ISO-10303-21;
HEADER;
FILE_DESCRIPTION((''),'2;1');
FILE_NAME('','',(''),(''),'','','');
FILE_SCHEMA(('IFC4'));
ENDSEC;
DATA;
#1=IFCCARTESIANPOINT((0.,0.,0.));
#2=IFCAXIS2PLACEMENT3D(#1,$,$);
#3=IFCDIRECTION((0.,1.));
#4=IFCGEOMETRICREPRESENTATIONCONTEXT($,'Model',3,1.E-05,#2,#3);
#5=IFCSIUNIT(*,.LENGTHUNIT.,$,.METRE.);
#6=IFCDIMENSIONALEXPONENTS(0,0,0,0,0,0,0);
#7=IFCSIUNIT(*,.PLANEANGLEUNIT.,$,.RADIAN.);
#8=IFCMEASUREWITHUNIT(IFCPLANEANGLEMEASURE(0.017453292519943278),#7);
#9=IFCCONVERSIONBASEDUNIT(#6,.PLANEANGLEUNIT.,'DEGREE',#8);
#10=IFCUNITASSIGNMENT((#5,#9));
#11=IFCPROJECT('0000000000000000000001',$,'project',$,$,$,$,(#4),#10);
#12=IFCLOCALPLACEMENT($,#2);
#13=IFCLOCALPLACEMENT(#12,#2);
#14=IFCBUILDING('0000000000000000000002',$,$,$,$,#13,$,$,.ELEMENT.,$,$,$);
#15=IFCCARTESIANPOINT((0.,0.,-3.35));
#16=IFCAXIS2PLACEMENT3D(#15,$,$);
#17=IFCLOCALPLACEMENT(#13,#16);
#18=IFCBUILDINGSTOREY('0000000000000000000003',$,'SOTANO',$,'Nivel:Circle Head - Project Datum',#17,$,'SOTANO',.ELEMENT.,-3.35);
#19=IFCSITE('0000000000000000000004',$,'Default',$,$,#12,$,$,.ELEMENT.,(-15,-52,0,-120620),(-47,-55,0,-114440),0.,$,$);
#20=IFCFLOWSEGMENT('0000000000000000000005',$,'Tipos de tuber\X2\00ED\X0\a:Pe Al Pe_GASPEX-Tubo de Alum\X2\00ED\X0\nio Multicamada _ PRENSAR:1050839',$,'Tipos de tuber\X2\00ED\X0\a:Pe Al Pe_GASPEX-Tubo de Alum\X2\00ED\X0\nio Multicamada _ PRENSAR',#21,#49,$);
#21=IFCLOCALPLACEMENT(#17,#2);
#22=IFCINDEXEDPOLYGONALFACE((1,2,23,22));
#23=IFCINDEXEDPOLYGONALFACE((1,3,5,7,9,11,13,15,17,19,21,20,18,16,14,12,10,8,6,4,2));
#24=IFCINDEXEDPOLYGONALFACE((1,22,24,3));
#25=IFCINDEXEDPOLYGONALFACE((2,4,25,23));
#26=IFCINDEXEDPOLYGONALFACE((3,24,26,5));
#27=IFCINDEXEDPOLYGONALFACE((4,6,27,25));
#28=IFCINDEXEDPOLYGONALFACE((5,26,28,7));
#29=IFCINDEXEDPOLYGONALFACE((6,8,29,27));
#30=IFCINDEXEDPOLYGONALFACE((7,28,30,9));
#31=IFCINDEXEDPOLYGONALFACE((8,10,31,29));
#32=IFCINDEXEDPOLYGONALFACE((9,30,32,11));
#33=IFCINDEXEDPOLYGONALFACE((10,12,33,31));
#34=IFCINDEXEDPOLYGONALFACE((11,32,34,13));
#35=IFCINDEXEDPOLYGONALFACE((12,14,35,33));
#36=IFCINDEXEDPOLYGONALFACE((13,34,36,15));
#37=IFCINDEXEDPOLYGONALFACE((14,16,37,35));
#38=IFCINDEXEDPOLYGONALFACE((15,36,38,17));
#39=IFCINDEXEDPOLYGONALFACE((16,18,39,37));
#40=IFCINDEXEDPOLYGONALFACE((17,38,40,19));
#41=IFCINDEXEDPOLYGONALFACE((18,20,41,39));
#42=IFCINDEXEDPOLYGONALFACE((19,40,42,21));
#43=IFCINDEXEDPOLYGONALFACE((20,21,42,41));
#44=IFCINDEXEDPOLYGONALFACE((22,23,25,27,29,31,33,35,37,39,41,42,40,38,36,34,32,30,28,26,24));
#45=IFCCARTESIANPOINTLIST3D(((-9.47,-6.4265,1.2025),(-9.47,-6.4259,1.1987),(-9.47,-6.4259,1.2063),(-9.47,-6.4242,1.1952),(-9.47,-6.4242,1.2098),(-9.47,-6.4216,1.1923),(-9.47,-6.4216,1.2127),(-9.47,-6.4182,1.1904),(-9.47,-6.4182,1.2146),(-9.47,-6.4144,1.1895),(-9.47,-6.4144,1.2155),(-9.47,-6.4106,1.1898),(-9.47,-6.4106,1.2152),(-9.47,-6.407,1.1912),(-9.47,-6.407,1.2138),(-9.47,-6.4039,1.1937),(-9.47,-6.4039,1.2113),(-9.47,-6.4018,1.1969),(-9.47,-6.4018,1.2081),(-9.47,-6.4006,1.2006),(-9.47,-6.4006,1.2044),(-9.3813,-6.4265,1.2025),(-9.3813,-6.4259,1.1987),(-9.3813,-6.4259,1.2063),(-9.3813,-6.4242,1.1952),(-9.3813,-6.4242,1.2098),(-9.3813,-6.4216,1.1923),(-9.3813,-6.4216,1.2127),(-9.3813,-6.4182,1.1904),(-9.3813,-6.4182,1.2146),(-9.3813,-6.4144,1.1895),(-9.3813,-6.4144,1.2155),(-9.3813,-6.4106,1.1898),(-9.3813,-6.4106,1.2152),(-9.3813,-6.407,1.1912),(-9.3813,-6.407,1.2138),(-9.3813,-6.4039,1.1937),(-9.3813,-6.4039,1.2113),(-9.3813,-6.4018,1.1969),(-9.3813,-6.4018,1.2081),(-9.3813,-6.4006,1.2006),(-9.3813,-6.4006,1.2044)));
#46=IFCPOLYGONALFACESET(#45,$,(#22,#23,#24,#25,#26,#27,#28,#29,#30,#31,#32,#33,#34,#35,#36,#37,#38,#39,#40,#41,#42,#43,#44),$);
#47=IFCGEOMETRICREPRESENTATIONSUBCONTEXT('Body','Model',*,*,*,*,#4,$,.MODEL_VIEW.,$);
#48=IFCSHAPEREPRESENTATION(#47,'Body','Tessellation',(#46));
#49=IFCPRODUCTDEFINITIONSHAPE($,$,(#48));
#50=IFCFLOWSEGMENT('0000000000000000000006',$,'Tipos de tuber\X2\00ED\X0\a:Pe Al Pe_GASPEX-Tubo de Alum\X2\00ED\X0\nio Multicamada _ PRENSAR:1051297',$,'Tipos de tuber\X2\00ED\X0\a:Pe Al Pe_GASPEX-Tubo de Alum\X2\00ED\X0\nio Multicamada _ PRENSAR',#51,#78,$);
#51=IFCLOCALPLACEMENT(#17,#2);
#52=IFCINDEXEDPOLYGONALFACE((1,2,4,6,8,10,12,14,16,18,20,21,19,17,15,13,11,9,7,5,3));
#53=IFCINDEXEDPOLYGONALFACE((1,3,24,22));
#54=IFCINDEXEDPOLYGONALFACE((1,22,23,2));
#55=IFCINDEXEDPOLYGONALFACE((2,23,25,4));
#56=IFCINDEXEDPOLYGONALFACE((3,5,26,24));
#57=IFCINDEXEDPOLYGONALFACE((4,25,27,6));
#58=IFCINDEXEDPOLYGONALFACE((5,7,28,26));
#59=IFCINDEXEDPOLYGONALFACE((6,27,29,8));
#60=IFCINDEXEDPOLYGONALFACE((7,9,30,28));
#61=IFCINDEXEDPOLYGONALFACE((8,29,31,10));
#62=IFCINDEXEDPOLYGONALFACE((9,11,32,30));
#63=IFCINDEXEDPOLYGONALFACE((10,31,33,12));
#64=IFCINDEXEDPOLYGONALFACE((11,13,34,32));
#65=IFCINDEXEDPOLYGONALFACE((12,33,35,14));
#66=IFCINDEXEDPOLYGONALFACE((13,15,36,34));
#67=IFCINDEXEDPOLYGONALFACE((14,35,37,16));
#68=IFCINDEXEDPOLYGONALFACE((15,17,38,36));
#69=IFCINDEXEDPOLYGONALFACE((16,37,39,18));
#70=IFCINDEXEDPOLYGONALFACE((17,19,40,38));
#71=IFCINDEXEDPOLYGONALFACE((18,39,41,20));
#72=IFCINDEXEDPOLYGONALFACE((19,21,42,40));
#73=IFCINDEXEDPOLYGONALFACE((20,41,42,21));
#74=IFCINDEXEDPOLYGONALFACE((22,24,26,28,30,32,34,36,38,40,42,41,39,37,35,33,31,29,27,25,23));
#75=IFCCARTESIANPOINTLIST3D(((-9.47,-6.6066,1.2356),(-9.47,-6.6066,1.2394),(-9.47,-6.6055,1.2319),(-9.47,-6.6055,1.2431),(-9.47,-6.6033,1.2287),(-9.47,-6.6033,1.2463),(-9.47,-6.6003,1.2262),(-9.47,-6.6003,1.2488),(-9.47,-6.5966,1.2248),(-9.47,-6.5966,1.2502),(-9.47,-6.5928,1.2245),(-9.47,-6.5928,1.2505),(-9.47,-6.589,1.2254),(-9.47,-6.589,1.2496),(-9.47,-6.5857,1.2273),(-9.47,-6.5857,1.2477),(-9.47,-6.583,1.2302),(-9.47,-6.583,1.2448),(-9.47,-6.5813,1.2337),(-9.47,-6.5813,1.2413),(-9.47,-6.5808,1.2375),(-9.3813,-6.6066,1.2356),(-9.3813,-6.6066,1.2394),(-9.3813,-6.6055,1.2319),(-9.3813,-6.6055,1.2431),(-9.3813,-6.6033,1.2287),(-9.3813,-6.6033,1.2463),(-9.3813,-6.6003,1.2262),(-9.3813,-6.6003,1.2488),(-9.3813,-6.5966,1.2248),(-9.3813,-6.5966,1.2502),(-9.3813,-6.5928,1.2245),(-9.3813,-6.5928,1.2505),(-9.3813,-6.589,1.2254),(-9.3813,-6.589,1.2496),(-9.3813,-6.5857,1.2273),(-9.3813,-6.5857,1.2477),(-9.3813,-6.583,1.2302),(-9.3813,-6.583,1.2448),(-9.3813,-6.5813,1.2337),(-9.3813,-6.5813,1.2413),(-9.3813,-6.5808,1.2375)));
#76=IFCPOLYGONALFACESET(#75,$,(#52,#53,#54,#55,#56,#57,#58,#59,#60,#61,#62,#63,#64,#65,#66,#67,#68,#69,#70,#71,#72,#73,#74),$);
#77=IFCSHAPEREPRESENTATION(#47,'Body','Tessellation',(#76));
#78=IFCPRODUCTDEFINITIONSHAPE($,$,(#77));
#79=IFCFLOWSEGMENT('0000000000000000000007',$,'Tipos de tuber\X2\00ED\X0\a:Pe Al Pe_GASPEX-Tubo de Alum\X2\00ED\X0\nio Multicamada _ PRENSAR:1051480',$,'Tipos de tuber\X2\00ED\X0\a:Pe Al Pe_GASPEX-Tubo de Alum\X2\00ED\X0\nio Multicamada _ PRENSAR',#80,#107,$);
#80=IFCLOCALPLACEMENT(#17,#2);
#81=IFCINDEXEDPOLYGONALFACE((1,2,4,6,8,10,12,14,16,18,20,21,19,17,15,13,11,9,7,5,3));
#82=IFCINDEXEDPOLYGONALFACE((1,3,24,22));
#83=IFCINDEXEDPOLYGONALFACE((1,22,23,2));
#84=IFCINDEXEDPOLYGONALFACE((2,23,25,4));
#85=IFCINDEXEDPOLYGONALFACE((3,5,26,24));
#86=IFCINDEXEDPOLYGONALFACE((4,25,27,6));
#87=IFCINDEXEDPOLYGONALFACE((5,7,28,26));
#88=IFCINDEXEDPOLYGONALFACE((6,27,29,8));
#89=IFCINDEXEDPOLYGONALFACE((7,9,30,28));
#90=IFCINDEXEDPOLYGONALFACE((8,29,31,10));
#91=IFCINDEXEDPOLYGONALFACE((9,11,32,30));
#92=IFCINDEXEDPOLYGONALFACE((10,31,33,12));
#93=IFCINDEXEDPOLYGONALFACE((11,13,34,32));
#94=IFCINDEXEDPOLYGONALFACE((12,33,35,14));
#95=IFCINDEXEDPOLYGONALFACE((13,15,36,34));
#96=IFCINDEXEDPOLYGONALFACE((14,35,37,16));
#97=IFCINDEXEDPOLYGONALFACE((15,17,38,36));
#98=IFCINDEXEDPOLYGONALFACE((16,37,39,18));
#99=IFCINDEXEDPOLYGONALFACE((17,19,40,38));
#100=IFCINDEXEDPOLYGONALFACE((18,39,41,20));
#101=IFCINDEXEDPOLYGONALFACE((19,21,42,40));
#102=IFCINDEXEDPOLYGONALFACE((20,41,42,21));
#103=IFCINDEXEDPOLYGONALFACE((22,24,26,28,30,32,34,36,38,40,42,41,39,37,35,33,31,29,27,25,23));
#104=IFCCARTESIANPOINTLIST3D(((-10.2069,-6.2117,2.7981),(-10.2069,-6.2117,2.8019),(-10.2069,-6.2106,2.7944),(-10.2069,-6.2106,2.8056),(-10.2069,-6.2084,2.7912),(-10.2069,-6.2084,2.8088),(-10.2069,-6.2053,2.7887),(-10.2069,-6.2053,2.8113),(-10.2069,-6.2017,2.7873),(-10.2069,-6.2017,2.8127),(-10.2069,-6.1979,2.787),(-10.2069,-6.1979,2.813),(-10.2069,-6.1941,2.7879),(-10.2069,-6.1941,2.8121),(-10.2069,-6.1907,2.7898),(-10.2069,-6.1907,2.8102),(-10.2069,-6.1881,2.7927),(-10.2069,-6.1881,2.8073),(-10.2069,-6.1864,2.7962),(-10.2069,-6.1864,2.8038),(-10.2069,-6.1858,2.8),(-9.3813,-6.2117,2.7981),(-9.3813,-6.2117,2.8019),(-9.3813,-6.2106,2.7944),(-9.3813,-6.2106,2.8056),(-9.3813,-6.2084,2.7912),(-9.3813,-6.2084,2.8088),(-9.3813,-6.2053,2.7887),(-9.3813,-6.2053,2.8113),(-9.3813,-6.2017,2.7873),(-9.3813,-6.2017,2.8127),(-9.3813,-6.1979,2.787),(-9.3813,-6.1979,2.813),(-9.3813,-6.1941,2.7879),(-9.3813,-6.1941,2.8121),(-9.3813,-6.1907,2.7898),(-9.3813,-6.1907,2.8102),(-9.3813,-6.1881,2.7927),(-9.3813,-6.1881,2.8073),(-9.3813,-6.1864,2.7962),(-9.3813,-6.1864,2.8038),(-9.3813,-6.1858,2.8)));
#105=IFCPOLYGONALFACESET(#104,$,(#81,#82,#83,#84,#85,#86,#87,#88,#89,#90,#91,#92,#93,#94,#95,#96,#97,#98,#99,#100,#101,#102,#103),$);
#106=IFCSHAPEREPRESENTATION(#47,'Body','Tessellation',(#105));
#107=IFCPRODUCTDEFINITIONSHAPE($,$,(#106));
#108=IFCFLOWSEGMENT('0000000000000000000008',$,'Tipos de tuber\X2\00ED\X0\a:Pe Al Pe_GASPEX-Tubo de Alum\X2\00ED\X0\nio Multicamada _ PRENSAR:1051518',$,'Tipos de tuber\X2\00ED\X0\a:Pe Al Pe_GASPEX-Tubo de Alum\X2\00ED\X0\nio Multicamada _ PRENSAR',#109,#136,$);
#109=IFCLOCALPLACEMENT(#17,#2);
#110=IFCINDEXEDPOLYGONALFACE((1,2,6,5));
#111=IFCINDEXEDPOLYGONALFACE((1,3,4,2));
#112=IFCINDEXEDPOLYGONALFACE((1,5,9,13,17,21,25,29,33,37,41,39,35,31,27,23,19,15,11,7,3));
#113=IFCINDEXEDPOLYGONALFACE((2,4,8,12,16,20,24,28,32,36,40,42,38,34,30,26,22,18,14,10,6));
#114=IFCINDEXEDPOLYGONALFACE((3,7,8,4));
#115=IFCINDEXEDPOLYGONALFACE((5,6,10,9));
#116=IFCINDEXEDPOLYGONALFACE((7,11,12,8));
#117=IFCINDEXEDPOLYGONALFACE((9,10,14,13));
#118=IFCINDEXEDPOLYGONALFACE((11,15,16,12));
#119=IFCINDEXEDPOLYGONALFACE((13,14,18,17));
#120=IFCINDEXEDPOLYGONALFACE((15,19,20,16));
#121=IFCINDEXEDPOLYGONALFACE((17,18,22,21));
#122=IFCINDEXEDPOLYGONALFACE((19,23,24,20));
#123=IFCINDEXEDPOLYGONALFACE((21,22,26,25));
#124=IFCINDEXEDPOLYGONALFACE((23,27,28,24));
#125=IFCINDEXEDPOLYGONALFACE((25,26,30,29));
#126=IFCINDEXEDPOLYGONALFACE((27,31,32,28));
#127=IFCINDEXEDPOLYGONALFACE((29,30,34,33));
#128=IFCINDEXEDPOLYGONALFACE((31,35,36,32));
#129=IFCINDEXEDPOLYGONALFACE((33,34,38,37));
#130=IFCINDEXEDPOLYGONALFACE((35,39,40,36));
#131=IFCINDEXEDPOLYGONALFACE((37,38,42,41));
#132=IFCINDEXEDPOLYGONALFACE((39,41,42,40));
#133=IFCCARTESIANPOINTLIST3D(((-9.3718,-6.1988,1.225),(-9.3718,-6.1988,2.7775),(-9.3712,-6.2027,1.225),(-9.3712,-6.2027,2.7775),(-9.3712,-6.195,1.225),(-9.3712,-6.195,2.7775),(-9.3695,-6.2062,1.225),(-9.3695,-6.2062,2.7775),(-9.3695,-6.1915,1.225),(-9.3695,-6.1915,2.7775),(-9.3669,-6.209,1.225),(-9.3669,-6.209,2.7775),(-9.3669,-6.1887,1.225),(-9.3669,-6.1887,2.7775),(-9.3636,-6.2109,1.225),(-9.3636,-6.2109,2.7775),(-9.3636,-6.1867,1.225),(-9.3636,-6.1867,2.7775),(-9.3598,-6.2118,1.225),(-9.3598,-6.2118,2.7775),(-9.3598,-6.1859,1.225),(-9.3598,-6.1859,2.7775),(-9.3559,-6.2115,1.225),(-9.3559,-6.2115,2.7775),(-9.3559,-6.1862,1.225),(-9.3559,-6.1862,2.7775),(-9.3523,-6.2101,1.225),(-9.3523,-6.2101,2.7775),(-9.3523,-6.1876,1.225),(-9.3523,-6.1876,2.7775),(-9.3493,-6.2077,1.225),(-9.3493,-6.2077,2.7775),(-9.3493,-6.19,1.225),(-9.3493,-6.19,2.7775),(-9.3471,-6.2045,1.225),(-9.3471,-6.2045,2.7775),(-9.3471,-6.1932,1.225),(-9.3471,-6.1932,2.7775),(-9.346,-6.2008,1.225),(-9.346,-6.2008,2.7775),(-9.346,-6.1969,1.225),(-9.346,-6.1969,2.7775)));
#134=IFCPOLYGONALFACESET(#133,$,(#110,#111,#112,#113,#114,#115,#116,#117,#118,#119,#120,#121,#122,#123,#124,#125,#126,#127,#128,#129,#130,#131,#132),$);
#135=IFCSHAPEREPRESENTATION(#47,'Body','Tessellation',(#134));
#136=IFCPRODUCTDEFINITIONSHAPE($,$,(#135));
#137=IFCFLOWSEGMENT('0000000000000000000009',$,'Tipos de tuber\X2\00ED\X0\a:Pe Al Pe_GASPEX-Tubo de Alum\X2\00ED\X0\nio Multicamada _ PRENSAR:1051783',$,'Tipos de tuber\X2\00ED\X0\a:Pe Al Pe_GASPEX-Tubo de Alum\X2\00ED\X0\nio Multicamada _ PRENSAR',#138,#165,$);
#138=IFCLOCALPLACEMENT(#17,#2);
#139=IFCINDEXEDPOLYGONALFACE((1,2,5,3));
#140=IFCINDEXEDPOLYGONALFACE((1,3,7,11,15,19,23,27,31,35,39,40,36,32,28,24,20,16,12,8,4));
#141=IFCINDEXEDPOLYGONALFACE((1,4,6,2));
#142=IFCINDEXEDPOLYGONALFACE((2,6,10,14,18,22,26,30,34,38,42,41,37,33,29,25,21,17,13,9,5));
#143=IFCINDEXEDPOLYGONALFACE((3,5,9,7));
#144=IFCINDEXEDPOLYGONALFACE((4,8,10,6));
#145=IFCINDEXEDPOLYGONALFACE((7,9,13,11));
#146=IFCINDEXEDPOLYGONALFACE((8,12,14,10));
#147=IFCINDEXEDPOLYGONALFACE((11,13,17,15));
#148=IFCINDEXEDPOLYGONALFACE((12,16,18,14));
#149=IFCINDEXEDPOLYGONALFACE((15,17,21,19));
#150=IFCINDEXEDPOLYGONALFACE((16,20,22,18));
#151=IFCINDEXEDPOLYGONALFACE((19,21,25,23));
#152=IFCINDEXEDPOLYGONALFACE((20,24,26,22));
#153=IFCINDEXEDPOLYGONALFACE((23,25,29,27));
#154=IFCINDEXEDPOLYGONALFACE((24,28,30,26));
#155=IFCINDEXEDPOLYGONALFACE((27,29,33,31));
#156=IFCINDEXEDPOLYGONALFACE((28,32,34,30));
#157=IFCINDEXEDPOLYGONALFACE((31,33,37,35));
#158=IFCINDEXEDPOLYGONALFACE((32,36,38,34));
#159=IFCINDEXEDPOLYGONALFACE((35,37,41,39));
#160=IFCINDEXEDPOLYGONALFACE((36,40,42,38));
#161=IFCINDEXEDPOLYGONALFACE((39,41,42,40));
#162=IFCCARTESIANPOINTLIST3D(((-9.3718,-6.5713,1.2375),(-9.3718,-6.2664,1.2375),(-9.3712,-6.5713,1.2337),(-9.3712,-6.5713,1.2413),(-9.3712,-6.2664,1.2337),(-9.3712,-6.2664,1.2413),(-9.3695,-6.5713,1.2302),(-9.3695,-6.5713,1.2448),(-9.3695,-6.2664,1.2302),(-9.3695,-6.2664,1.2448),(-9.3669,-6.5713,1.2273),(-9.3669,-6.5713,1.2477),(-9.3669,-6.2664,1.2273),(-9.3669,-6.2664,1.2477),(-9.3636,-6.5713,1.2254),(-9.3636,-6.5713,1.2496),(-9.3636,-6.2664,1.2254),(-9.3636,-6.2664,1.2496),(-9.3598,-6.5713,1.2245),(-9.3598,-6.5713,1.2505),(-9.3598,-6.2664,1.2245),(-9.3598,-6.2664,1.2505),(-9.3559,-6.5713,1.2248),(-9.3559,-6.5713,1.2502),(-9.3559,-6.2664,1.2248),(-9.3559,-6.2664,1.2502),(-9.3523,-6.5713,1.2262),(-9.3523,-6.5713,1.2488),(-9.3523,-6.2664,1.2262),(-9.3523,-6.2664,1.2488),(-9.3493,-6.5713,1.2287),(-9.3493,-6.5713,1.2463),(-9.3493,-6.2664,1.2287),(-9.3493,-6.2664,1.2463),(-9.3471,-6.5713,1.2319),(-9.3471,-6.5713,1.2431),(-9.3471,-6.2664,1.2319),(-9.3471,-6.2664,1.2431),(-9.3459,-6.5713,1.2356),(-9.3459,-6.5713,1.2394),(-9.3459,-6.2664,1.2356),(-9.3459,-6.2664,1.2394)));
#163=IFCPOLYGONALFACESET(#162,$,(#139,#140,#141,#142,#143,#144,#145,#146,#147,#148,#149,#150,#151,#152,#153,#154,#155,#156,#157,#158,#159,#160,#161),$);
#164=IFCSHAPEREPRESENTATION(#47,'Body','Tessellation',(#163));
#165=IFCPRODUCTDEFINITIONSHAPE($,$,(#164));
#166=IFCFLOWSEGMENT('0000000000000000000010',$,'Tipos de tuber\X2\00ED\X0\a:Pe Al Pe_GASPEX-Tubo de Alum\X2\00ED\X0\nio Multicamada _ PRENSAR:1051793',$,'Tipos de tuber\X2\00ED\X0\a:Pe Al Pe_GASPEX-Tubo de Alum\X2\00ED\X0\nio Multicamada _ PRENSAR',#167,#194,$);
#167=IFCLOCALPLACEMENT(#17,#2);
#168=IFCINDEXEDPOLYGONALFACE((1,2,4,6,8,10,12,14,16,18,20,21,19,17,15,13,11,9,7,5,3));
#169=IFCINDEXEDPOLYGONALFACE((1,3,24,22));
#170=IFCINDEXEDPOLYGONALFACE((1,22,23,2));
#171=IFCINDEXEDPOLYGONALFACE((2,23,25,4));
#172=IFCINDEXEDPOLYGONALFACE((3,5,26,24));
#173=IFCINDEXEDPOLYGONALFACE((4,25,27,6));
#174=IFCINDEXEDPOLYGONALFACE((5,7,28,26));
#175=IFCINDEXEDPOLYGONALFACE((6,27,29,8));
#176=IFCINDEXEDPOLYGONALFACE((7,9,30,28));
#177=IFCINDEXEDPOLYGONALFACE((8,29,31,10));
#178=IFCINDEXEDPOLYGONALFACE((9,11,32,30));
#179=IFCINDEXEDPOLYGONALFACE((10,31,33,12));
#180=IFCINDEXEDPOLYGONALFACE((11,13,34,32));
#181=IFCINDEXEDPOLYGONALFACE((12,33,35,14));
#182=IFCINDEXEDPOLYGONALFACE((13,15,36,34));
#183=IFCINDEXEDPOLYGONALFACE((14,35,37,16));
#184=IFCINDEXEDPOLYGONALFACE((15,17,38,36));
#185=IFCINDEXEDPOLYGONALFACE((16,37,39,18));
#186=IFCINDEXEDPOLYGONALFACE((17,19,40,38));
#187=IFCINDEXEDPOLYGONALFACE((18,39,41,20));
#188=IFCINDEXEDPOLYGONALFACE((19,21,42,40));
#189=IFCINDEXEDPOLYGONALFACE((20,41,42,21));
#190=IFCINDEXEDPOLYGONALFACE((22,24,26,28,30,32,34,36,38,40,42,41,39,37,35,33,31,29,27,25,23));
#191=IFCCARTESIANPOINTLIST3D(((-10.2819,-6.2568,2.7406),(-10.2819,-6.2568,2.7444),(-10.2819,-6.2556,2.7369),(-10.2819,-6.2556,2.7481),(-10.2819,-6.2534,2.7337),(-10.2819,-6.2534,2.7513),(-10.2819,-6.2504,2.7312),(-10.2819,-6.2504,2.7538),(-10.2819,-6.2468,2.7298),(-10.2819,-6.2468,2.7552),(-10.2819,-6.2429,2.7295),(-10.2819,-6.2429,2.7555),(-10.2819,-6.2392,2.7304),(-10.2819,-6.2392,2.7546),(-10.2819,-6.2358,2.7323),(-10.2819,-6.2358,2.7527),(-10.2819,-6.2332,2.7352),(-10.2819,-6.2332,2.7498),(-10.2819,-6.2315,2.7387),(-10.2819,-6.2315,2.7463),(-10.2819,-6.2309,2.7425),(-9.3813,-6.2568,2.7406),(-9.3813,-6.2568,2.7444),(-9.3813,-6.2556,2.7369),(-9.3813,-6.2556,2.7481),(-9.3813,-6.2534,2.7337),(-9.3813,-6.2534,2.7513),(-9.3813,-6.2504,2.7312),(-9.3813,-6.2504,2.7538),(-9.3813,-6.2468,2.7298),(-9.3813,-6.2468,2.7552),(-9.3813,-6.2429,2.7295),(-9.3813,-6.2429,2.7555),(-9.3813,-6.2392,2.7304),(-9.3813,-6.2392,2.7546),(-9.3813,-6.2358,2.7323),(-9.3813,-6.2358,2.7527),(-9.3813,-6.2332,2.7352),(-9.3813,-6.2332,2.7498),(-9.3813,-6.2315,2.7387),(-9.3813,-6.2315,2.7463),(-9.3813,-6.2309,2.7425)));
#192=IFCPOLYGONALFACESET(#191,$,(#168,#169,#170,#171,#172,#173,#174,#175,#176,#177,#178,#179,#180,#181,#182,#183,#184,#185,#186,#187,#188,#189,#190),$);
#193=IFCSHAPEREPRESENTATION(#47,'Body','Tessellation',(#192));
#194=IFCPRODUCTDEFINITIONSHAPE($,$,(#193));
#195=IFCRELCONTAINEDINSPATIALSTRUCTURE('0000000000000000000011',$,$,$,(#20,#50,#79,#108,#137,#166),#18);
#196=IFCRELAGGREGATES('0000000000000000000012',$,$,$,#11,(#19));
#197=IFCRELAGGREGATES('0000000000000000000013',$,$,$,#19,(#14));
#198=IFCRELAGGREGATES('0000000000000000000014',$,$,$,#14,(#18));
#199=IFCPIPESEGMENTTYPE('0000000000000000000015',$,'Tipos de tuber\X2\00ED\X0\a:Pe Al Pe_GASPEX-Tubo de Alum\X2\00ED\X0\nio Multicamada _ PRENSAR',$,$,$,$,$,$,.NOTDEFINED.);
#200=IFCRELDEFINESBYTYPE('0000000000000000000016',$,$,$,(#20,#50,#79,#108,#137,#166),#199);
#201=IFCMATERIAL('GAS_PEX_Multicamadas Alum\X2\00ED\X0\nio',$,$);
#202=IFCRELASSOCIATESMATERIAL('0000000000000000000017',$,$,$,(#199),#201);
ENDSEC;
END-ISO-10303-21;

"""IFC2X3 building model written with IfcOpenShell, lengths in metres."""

from ifc_helpers import new_model, entity, si_unit, converted_unit, direction, frame, frame_2d, origin, origin_2d_with_axis, place, context, subcontext, project, spatial, circle, extrude, material, type_object, element, save


model = new_model("IFC2X3")

# Units and contexts
model_context = context("Model", 3, precision=1e-05, world=origin(), true_north=direction((0.0, 1.0)))
body_context = subcontext(model_context, "Body", "Model", "MODEL_VIEW")
ifc_project = project(units=[si_unit("LENGTHUNIT", "METRE"), converted_unit("PLANEANGLEUNIT", "DEGREE", entity("IfcPlaneAngleMeasure", 0.017453292519943278), si_unit("PLANEANGLEUNIT", "RADIAN"), dimensions=[0, 0, 0, 0, 0, 0, 0])], contexts=[model_context])

# Site, building, storey
site_placement = place(None, origin())
site = spatial("IfcSite", under=ifc_project, at=site_placement, Name="Default", CompositionType="ELEMENT", RefLatitude=(-15, -52, 0, -120620), RefLongitude=(-47, -55, 0, -114440), RefElevation=0.0)
building_placement = place(site_placement, origin())
building = spatial("IfcBuilding", under=site, at=building_placement, CompositionType="ELEMENT")
storey_placement = place(building_placement, frame((0.0, 0.0, -3.35)))
storey = spatial("IfcBuildingStorey", under=building, at=storey_placement, Name="SOTANO", ObjectType="Nivel:Circle Head - Project Datum", LongName="SOTANO", CompositionType="ELEMENT", Elevation=-3.35)

# Flow segments
ifc_material = material(Name="GAS_PEX_Multicamadas Alumínio")
pipe_segment_type_1 = type_object("IfcPipeSegmentType", Name="Tipos de tubería:Pe Al Pe_GASPEX-Tubo de Alumínio Multicamada _ PRENSAR", PredefinedType="NOTDEFINED", material=ifc_material)
flow_segment_1_placement = place(storey_placement, origin())
element("IfcFlowSegment", 1, at=flow_segment_1_placement, inside=storey, type_object=pipe_segment_type_1, Name="Tipos de tubería:Pe Al Pe_GASPEX-Tubo de Alumínio Multicamada _ PRENSAR:1050839", ObjectType="Tipos de tubería:Pe Al Pe_GASPEX-Tubo de Alumínio Multicamada _ PRENSAR", context=body_context, shape_type="SweptSolid", body=[
    extrude(circle(Radius=0.013, at=frame_2d((0.0, 0.0), x_axis=(1.0, 0.0))), frame((-9.47, -6.4135, 1.2025), z_axis=(1.0, -0.000001, 0.0), x_axis=(-0.000001, -1.0, 0.0)), (0.0, 0.0, 1.0), 0.0887),
])
flow_segment_2_placement = place(storey_placement, origin())
element("IfcFlowSegment", 2, at=flow_segment_2_placement, inside=storey, type_object=pipe_segment_type_1, Name="Tipos de tubería:Pe Al Pe_GASPEX-Tubo de Alumínio Multicamada _ PRENSAR:1051297", ObjectType="Tipos de tubería:Pe Al Pe_GASPEX-Tubo de Alumínio Multicamada _ PRENSAR", context=body_context, shape_type="SweptSolid", body=[
    extrude(circle(Radius=0.013, at=frame_2d((0.0, 0.0), x_axis=(1.0, 0.0))), frame((-9.47, -6.5938, 1.2375), z_axis=(1.0, 0.0, 0.0), x_axis=(0.0, 1.0, 0.0)), (0.0, 0.0, 1.0), 0.0887),
])
flow_segment_3_placement = place(storey_placement, origin())
element("IfcFlowSegment", 3, at=flow_segment_3_placement, inside=storey, type_object=pipe_segment_type_1, Name="Tipos de tubería:Pe Al Pe_GASPEX-Tubo de Alumínio Multicamada _ PRENSAR:1051480", ObjectType="Tipos de tubería:Pe Al Pe_GASPEX-Tubo de Alumínio Multicamada _ PRENSAR", context=body_context, shape_type="SweptSolid", body=[
    extrude(circle(Radius=0.013, at=origin_2d_with_axis()), frame((-10.2069, -6.1988, 2.8), z_axis=(1.0, 0.0, 0.0), x_axis=(0.0, 1.0, 0.0)), (0.0, 0.0, 1.0), 0.8256),
])
flow_segment_4_placement = place(storey_placement, origin())
element("IfcFlowSegment", 4, at=flow_segment_4_placement, inside=storey, type_object=pipe_segment_type_1, Name="Tipos de tubería:Pe Al Pe_GASPEX-Tubo de Alumínio Multicamada _ PRENSAR:1051518", ObjectType="Tipos de tubería:Pe Al Pe_GASPEX-Tubo de Alumínio Multicamada _ PRENSAR", context=body_context, shape_type="SweptSolid", body=[
    extrude(circle(Radius=0.013, at=origin_2d_with_axis()), frame((-9.3588, -6.1988, 1.225), z_axis=(0.0, 0.0, 1.0), x_axis=(-1.0, 0.0, 0.0)), (0.0, 0.0, 1.0), 1.5525),
])
flow_segment_5_placement = place(storey_placement, origin())
element("IfcFlowSegment", 5, at=flow_segment_5_placement, inside=storey, type_object=pipe_segment_type_1, Name="Tipos de tubería:Pe Al Pe_GASPEX-Tubo de Alumínio Multicamada _ PRENSAR:1051783", ObjectType="Tipos de tubería:Pe Al Pe_GASPEX-Tubo de Alumínio Multicamada _ PRENSAR", context=body_context, shape_type="SweptSolid", body=[
    extrude(circle(Radius=0.013, at=origin_2d_with_axis()), frame((-9.3588, -6.5713, 1.2375), z_axis=(0.0, 1.0, 0.0), x_axis=(-1.0, 0.0, 0.0)), (0.0, 0.0, 1.0), 0.3048),
])
flow_segment_6_placement = place(storey_placement, origin())
element("IfcFlowSegment", 6, at=flow_segment_6_placement, inside=storey, type_object=pipe_segment_type_1, Name="Tipos de tubería:Pe Al Pe_GASPEX-Tubo de Alumínio Multicamada _ PRENSAR:1051793", ObjectType="Tipos de tubería:Pe Al Pe_GASPEX-Tubo de Alumínio Multicamada _ PRENSAR", context=body_context, shape_type="SweptSolid", body=[
    extrude(circle(Radius=0.013, at=frame_2d((0.0, 0.0), x_axis=(1.0, 0.0))), frame((-10.2819, -6.2439, 2.7425), z_axis=(1.0, 0.0, 0.0), x_axis=(0.0, 1.0, 0.0)), (0.0, 0.0, 1.0), 0.9006),
])

save(model, "model.ifc")
